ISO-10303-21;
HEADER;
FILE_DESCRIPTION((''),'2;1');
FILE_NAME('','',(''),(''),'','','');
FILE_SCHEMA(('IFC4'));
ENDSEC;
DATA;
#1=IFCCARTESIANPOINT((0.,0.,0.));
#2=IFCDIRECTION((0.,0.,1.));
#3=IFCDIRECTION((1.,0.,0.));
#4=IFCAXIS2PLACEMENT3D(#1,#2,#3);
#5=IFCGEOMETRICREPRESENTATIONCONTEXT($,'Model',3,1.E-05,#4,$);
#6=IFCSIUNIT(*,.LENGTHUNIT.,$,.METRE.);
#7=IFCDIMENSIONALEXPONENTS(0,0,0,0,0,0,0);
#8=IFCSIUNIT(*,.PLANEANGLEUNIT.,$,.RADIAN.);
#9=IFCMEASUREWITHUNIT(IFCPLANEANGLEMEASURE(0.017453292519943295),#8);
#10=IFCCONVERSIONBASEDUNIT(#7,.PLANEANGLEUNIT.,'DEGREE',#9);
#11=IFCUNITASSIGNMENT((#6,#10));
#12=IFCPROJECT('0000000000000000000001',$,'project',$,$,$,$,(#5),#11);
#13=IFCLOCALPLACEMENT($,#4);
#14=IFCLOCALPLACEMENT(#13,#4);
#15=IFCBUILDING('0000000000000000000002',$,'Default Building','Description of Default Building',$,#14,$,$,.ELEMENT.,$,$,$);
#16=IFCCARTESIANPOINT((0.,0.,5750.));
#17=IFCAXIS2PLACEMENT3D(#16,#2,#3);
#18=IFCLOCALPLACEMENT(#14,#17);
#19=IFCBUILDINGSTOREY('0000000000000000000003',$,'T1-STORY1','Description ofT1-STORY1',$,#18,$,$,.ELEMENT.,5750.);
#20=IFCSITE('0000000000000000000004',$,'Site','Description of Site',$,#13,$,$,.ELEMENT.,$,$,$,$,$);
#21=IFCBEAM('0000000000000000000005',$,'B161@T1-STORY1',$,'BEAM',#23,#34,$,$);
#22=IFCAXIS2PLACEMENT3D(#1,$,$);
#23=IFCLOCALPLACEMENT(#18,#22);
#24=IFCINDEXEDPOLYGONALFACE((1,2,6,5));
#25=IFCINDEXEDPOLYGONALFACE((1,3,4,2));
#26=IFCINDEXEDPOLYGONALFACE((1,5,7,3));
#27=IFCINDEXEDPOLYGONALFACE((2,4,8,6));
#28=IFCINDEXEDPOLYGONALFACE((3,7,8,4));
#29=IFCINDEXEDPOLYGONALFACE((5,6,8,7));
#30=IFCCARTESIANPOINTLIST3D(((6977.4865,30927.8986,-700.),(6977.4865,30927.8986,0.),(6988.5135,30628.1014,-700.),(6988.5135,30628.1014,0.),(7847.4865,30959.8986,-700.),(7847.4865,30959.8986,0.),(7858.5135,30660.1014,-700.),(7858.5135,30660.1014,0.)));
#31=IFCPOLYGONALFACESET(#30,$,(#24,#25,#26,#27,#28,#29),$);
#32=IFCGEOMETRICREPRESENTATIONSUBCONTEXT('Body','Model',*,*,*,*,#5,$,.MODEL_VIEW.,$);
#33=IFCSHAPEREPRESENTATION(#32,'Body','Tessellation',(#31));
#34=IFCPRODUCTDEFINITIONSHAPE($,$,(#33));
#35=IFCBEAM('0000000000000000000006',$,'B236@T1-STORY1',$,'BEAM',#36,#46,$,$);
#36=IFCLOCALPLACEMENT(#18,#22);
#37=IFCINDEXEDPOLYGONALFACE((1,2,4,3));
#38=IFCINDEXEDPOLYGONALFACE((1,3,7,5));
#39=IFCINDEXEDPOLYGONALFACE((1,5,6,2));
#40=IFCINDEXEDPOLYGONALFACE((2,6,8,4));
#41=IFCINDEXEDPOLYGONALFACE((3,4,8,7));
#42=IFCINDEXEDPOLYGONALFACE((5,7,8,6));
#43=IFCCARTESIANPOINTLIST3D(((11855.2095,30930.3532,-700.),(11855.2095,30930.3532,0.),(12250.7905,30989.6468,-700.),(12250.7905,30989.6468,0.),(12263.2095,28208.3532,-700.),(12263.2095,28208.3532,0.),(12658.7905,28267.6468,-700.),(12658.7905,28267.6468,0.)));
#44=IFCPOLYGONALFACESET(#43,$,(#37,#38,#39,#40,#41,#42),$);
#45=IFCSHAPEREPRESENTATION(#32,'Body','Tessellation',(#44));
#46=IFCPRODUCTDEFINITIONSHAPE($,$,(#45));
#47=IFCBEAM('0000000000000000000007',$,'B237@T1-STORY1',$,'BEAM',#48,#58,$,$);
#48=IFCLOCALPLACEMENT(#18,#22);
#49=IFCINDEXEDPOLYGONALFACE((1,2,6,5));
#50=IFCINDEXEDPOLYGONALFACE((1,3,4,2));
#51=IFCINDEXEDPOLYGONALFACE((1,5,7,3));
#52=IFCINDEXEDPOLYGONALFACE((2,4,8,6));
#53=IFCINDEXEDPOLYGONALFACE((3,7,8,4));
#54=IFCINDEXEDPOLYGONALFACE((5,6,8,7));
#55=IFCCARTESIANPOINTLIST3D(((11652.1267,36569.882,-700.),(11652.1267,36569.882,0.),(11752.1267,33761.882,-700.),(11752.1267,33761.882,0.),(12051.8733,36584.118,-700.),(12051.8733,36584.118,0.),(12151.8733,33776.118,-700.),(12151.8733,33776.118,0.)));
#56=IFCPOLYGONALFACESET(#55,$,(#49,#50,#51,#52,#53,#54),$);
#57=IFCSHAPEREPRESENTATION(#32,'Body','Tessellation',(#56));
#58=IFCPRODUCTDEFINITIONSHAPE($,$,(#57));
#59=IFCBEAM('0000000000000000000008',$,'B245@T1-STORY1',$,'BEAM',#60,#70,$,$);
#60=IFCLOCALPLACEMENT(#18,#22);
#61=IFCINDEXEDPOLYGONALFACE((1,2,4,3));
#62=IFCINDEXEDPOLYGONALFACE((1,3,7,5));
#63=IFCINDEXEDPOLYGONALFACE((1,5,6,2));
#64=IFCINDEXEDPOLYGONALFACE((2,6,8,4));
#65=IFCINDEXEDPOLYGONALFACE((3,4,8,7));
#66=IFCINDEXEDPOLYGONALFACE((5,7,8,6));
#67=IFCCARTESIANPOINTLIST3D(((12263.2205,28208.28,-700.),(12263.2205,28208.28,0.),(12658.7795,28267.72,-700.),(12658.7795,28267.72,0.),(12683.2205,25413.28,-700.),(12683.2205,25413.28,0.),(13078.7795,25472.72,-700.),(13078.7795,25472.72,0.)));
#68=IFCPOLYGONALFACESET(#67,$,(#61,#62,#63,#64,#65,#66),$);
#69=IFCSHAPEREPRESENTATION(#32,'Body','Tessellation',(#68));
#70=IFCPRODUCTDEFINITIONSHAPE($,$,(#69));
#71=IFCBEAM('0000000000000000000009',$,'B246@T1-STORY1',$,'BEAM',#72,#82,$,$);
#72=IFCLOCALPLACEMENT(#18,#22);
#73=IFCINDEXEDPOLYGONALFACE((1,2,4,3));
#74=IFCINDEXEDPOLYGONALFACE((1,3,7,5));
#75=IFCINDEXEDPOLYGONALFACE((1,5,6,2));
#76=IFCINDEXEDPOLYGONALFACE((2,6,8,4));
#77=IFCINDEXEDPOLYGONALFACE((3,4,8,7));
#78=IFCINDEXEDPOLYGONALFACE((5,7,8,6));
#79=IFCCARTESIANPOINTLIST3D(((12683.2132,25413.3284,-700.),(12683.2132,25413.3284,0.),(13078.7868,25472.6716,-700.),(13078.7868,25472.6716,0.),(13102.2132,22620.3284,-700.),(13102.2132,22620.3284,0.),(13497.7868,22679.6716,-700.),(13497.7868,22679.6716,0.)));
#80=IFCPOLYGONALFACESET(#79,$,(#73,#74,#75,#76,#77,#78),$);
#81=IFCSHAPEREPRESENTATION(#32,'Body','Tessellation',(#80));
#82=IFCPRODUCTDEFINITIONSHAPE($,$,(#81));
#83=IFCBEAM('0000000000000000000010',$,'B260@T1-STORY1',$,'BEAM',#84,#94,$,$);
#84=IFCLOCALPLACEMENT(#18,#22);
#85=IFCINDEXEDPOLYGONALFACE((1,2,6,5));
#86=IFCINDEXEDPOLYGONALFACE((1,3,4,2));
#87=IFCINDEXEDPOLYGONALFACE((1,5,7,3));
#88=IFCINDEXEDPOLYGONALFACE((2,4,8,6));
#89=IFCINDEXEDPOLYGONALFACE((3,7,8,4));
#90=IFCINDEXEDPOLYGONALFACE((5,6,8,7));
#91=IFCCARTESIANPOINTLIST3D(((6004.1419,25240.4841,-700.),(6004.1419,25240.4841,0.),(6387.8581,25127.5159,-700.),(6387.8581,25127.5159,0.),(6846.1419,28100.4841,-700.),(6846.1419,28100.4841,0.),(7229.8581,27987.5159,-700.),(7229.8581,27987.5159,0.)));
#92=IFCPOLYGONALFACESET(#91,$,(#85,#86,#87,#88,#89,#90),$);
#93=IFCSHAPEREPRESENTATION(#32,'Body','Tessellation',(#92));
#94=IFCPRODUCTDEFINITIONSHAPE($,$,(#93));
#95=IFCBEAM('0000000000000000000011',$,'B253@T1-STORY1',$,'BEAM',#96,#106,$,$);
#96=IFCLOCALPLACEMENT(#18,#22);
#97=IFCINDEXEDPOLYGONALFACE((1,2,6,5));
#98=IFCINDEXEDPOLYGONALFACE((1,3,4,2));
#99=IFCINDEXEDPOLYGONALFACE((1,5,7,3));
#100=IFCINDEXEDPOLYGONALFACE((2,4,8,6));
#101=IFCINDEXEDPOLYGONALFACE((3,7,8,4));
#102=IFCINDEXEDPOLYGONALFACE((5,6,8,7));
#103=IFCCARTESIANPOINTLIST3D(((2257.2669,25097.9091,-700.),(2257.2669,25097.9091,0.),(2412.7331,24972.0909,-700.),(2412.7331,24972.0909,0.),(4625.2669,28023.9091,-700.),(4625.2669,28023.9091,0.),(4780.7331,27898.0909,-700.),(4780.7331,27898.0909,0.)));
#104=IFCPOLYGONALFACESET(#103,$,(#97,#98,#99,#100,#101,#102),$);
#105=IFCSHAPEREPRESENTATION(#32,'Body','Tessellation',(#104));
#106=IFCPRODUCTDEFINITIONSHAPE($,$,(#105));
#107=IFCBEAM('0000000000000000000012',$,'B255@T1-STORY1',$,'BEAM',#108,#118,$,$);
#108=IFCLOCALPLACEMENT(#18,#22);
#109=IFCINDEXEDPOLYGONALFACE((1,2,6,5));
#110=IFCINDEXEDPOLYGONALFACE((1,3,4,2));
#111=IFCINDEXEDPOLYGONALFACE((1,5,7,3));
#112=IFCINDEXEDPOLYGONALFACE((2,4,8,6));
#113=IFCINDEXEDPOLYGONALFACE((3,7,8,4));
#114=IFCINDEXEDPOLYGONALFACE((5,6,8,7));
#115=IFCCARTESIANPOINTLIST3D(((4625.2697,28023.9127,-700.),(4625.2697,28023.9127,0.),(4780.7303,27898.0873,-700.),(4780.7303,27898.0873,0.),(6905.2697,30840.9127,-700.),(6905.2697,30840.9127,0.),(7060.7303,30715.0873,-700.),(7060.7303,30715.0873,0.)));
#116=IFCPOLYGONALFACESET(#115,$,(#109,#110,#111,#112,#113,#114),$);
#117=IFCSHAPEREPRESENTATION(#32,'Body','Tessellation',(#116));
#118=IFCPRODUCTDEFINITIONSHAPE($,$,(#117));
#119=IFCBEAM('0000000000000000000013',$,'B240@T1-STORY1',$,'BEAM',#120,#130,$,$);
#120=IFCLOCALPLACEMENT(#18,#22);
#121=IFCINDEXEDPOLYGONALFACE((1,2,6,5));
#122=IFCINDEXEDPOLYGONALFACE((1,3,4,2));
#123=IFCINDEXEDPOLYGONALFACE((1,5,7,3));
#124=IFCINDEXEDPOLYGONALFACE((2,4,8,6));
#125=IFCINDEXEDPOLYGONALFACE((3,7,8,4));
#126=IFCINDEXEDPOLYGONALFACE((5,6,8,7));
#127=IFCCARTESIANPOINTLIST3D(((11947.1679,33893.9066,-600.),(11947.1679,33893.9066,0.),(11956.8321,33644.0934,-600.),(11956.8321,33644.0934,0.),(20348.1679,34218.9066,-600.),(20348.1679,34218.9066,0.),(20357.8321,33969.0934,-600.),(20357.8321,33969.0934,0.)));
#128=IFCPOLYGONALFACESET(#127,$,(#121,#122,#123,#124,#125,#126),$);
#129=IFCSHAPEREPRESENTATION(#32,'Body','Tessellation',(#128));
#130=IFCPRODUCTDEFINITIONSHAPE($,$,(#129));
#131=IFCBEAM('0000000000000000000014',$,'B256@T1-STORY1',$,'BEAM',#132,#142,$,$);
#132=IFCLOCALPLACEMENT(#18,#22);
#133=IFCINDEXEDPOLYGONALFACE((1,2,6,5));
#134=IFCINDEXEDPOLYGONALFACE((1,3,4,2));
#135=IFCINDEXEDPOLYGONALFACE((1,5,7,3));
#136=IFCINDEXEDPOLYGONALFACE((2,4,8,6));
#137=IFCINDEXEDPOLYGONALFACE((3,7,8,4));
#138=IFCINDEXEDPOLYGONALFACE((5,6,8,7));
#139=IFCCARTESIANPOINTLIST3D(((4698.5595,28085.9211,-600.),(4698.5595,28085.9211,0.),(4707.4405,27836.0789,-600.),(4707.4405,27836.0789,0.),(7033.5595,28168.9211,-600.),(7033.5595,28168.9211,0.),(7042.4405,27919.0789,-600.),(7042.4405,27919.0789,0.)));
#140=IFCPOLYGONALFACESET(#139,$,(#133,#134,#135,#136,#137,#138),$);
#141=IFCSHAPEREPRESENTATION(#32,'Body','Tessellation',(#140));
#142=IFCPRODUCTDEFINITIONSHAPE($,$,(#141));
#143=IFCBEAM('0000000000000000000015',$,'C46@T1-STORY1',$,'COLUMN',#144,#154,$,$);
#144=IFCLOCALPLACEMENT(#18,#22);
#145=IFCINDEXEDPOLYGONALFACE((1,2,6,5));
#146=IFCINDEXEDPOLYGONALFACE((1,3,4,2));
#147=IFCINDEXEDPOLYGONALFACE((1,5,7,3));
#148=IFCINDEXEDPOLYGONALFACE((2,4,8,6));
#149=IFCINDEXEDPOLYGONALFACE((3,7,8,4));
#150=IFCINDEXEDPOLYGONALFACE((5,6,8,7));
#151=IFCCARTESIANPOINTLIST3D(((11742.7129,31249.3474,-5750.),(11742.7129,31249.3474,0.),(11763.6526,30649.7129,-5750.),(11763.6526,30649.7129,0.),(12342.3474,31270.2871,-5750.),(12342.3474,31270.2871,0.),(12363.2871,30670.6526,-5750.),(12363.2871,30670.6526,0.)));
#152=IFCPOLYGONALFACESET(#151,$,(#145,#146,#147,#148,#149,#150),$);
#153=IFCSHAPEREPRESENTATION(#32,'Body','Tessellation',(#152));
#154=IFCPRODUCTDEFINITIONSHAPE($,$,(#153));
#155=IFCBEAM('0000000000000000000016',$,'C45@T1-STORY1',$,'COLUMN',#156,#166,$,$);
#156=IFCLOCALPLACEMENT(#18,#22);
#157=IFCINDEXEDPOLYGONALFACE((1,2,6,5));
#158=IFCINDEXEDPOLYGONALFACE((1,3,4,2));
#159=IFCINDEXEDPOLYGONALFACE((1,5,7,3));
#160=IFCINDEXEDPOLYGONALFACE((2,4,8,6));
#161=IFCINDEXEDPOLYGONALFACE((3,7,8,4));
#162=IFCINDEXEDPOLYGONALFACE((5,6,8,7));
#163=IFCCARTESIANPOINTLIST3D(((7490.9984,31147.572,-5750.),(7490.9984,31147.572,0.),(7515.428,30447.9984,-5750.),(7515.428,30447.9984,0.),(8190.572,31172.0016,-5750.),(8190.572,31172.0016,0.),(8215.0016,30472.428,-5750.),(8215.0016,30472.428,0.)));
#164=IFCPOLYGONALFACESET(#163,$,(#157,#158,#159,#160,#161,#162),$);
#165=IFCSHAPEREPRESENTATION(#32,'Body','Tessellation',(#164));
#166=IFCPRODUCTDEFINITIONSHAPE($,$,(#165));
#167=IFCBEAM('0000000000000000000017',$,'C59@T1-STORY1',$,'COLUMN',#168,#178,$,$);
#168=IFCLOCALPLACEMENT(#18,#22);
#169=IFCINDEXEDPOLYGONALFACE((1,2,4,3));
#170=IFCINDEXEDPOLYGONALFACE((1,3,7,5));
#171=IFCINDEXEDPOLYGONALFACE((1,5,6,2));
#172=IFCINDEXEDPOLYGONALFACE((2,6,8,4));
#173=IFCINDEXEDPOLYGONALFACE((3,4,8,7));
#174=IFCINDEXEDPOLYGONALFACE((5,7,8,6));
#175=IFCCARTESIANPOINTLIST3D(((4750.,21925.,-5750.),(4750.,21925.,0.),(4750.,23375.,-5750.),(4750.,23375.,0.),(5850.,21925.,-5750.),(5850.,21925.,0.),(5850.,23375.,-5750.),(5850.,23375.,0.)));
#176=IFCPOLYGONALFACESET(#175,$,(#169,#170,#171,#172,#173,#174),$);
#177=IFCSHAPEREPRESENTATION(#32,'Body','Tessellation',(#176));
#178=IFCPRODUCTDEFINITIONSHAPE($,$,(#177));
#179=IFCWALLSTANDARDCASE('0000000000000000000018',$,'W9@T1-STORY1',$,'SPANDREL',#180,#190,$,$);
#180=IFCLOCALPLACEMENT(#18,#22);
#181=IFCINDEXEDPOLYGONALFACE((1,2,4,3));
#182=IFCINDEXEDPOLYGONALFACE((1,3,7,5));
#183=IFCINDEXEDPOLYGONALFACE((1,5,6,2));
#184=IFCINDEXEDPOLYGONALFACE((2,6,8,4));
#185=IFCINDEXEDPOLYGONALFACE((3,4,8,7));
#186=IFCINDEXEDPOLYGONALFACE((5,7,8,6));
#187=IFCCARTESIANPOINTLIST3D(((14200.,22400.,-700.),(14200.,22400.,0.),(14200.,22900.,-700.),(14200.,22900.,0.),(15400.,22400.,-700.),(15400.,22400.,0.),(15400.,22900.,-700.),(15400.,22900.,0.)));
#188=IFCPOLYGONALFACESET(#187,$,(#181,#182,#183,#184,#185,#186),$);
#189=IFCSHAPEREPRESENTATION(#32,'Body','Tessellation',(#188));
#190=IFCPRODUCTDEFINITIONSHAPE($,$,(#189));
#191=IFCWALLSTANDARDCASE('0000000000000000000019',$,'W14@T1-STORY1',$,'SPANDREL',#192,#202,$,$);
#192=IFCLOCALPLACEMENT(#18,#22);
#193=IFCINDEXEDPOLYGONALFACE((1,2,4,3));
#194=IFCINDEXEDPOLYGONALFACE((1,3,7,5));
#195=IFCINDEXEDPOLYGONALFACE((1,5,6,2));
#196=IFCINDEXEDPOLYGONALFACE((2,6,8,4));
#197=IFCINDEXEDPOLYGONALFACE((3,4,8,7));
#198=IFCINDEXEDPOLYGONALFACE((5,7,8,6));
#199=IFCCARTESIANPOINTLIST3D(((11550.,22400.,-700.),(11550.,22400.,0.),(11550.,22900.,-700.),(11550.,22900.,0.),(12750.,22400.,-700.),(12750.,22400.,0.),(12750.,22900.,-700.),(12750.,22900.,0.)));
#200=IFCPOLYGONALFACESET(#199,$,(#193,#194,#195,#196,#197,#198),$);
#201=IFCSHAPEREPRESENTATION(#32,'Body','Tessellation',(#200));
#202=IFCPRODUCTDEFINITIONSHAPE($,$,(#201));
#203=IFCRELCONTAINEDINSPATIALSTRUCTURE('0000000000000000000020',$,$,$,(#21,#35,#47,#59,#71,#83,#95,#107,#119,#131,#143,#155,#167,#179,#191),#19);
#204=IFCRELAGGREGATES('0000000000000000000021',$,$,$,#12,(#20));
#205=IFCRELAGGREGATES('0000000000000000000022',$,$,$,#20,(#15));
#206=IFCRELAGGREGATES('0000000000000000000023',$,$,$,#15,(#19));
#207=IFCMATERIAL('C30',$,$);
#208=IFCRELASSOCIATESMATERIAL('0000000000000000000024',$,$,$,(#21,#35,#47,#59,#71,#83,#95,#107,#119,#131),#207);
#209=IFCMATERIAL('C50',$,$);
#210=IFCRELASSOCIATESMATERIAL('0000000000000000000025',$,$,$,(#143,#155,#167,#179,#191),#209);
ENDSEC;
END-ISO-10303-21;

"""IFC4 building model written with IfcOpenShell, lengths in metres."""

from ifc_helpers import new_model, entity, si_unit, converted_unit, frame, origin_with_axes, place, context, subcontext, project, spatial, indexed_curve, rectangle, outline, extrude, material, element, save


model = new_model("IFC4")

# Units and contexts
model_context = context("Model", 3, precision=1e-05, world=origin_with_axes())
body_context = subcontext(model_context, "Body", "Model", "MODEL_VIEW")
ifc_project = project(units=[si_unit("LENGTHUNIT", "METRE"), converted_unit("PLANEANGLEUNIT", "DEGREE", entity("IfcPlaneAngleMeasure", 0.017453292519943295), si_unit("PLANEANGLEUNIT", "RADIAN"), dimensions=[0, 0, 0, 0, 0, 0, 0])], contexts=[model_context])

# Site, building, storey
site_placement = place(None, origin_with_axes())
site = spatial("IfcSite", under=ifc_project, at=site_placement, Name="Site", Description="Description of Site", CompositionType="ELEMENT")
building_placement = place(site_placement, origin_with_axes())
building = spatial("IfcBuilding", under=site, at=building_placement, Name="Default Building", Description="Description of Default Building", CompositionType="ELEMENT")
storey_placement = place(building_placement, frame((0.0, 0.0, 5750.0), z_axis=(0.0, 0.0, 1.0), x_axis=(1.0, 0.0, 0.0)))
storey = spatial("IfcBuildingStorey", under=building, at=storey_placement, Name="T1-STORY1", Description="Description ofT1-STORY1", CompositionType="ELEMENT", Elevation=5750.0)

# Beams
ifc_material_1 = material(Name="C30")
beam_1_placement = place(storey_placement, frame((6983.0, 30778.0, -350.0), z_axis=(0.999324, 0.036757, 0.0), x_axis=(-0.036757, 0.999324, 0.0)))
element("IfcBeam", 1, at=beam_1_placement, inside=storey, material=ifc_material_1, Name="B161@T1-STORY1", ObjectType="BEAM", context=body_context, shape_type="SweptSolid", body=[
    extrude(rectangle(XDim=300.0, YDim=700.0), origin_with_axes(), (0.0, 0.0, 1.0), 870.5883),
])
beam_2_placement = place(storey_placement, frame((12053.0, 30960.0, -350.0), z_axis=(0.148234, -0.988952, 0.0), x_axis=(0.988952, 0.148234, 0.0)))
element("IfcBeam", 2, at=beam_2_placement, inside=storey, material=ifc_material_1, Name="B236@T1-STORY1", ObjectType="BEAM", context=body_context, shape_type="SweptSolid", body=[
    extrude(rectangle(XDim=400.0, YDim=700.0), origin_with_axes(), (0.0, 0.0, 1.0), 2752.4077),
])
beam_3_placement = place(storey_placement, frame((11852.0, 36577.0, -350.0), z_axis=(0.03559, -0.999366, 0.0), x_axis=(0.999366, 0.03559, 0.0)))
element("IfcBeam", 3, at=beam_3_placement, inside=storey, material=ifc_material_1, Name="B237@T1-STORY1", ObjectType="BEAM", context=body_context, shape_type="SweptSolid", body=[
    extrude(rectangle(XDim=400.0, YDim=700.0), origin_with_axes(), (0.0, 0.0, 1.0), 2809.7801),
])
beam_4_placement = place(storey_placement, frame((12461.0, 28238.0, -350.0), z_axis=(0.1486, -0.988897, 0.0), x_axis=(0.988897, 0.1486, 0.0)))
element("IfcBeam", 4, at=beam_4_placement, inside=storey, material=ifc_material_1, Name="B245@T1-STORY1", ObjectType="BEAM", context=body_context, shape_type="SweptSolid", body=[
    extrude(rectangle(XDim=400.0, YDim=700.0), origin_with_axes(), (0.0, 0.0, 1.0), 2826.3802),
])
beam_5_placement = place(storey_placement, frame((12881.0, 25443.0, -350.0), z_axis=(0.148358, -0.988934, 0.0), x_axis=(0.988934, 0.148358, 0.0)))
element("IfcBeam", 5, at=beam_5_placement, inside=storey, material=ifc_material_1, Name="B246@T1-STORY1", ObjectType="BEAM", context=body_context, shape_type="SweptSolid", body=[
    extrude(rectangle(XDim=400.0, YDim=700.0), origin_with_axes(), (0.0, 0.0, 1.0), 2824.2539),
])
beam_6_placement = place(storey_placement, frame((6196.0, 25184.0, -350.0), z_axis=(0.282421, 0.959291, 0.0), x_axis=(-0.959291, 0.282421, 0.0)))
element("IfcBeam", 6, at=beam_6_placement, inside=storey, material=ifc_material_1, Name="B260@T1-STORY1", ObjectType="BEAM", context=body_context, shape_type="SweptSolid", body=[
    extrude(rectangle(XDim=400.0, YDim=700.0), origin_with_axes(), (0.0, 0.0, 1.0), 2981.3695),
])
beam_7_placement = place(storey_placement, frame((2335.0, 25035.0, -350.0), z_axis=(0.629091, 0.777331, 0.0), x_axis=(-0.777331, 0.629091, 0.0)))
element("IfcBeam", 7, at=beam_7_placement, inside=storey, material=ifc_material_1, Name="B253@T1-STORY1", ObjectType="BEAM", context=body_context, shape_type="SweptSolid", body=[
    extrude(rectangle(XDim=200.0, YDim=700.0), origin_with_axes(), (0.0, 0.0, 1.0), 3764.1599),
])
beam_8_placement = place(storey_placement, frame((4703.0, 27961.0, -350.0), z_axis=(0.629127, 0.777303, 0.0), x_axis=(-0.777303, 0.629127, 0.0)))
element("IfcBeam", 8, at=beam_8_placement, inside=storey, material=ifc_material_1, Name="B255@T1-STORY1", ObjectType="BEAM", context=body_context, shape_type="SweptSolid", body=[
    extrude(rectangle(XDim=200.0, YDim=700.0), origin_with_axes(), (0.0, 0.0, 1.0), 3624.0708),
])
beam_9_placement = place(storey_placement, frame((11952.0, 33769.0, -300.0), z_axis=(0.999253, 0.038657, 0.0), x_axis=(-0.038657, 0.999253, 0.0)))
element("IfcBeam", 9, at=beam_9_placement, inside=storey, material=ifc_material_1, Name="B240@T1-STORY1", ObjectType="BEAM", context=body_context, shape_type="SweptSolid", body=[
    extrude(rectangle(XDim=250.0, YDim=600.0), origin_with_axes(), (0.0, 0.0, 1.0), 8407.2841),
])
beam_10_placement = place(storey_placement, frame((4703.0, 27961.0, -300.0), z_axis=(0.999369, 0.035524, 0.0), x_axis=(-0.035524, 0.999369, 0.0)))
element("IfcBeam", 10, at=beam_10_placement, inside=storey, material=ifc_material_1, Name="B256@T1-STORY1", ObjectType="BEAM", context=body_context, shape_type="SweptSolid", body=[
    extrude(rectangle(XDim=250.0, YDim=600.0), origin_with_axes(), (0.0, 0.0, 1.0), 2336.4747),
])
ifc_material_2 = material(Name="C50")
beam_11_placement = place(storey_placement, frame((12053.0, 30960.0, -5750.0), z_axis=(0.0, 0.0, 1.0), x_axis=(-0.999391, -0.034899, 0.0)))
element("IfcBeam", 11, at=beam_11_placement, inside=storey, material=ifc_material_2, Name="C46@T1-STORY1", ObjectType="COLUMN", context=body_context, shape_type="SweptSolid", body=[
    extrude(rectangle(XDim=600.0, YDim=600.0), origin_with_axes(), (0.0, 0.0, 1.0), 5750.0),
])
beam_12_placement = place(storey_placement, frame((7853.0, 30810.0, -5750.0), z_axis=(0.0, 0.0, 1.0), x_axis=(-0.999391, -0.034899, 0.0)))
element("IfcBeam", 12, at=beam_12_placement, inside=storey, material=ifc_material_2, Name="C45@T1-STORY1", ObjectType="COLUMN", context=body_context, shape_type="SweptSolid", body=[
    extrude(rectangle(XDim=700.0, YDim=700.0), origin_with_axes(), (0.0, 0.0, 1.0), 5750.0),
])
beam_13_placement = place(storey_placement, frame((5300.0, 22650.0, -5750.0), z_axis=(0.0, 0.0, 1.0), x_axis=(-1.0, 0.0, 0.0)))
element("IfcBeam", 13, at=beam_13_placement, inside=storey, material=ifc_material_2, Name="C59@T1-STORY1", ObjectType="COLUMN", context=body_context, shape_type="SweptSolid", body=[
    extrude(rectangle(XDim=1100.0, YDim=1450.0), origin_with_axes(), (0.0, 0.0, 1.0), 5750.0),
])

# Walls
for number, where, z_axis, x_axis, name in (
    (14, (14200.0, 22650.0, -700.0), (0.0, 0.0, 1.0), (1.0, 0.0, 0.0), "W9@T1-STORY1"),
    (15, (11550.0, 22650.0, -700.0), (0.0, 0.0, 1.0), (1.0, 0.0, 0.0), "W14@T1-STORY1"),
):
    element("IfcWallStandardCase", number, at=place(storey_placement, frame(where, z_axis=z_axis, x_axis=x_axis)), inside=storey, material=ifc_material_2, Name=name, ObjectType="SPANDREL", context=body_context, shape_type="SweptSolid", body=[
        extrude(outline(indexed_curve([(0.0, -250.0), (0.0, 250.0), (1200.0, 250.0), (1200.0, -250.0), (0.0, -250.0)], self_intersect=False)), origin_with_axes(), (0.0, 0.0, 1.0), 700.0),
    ])

save(model, "model.ifc")
